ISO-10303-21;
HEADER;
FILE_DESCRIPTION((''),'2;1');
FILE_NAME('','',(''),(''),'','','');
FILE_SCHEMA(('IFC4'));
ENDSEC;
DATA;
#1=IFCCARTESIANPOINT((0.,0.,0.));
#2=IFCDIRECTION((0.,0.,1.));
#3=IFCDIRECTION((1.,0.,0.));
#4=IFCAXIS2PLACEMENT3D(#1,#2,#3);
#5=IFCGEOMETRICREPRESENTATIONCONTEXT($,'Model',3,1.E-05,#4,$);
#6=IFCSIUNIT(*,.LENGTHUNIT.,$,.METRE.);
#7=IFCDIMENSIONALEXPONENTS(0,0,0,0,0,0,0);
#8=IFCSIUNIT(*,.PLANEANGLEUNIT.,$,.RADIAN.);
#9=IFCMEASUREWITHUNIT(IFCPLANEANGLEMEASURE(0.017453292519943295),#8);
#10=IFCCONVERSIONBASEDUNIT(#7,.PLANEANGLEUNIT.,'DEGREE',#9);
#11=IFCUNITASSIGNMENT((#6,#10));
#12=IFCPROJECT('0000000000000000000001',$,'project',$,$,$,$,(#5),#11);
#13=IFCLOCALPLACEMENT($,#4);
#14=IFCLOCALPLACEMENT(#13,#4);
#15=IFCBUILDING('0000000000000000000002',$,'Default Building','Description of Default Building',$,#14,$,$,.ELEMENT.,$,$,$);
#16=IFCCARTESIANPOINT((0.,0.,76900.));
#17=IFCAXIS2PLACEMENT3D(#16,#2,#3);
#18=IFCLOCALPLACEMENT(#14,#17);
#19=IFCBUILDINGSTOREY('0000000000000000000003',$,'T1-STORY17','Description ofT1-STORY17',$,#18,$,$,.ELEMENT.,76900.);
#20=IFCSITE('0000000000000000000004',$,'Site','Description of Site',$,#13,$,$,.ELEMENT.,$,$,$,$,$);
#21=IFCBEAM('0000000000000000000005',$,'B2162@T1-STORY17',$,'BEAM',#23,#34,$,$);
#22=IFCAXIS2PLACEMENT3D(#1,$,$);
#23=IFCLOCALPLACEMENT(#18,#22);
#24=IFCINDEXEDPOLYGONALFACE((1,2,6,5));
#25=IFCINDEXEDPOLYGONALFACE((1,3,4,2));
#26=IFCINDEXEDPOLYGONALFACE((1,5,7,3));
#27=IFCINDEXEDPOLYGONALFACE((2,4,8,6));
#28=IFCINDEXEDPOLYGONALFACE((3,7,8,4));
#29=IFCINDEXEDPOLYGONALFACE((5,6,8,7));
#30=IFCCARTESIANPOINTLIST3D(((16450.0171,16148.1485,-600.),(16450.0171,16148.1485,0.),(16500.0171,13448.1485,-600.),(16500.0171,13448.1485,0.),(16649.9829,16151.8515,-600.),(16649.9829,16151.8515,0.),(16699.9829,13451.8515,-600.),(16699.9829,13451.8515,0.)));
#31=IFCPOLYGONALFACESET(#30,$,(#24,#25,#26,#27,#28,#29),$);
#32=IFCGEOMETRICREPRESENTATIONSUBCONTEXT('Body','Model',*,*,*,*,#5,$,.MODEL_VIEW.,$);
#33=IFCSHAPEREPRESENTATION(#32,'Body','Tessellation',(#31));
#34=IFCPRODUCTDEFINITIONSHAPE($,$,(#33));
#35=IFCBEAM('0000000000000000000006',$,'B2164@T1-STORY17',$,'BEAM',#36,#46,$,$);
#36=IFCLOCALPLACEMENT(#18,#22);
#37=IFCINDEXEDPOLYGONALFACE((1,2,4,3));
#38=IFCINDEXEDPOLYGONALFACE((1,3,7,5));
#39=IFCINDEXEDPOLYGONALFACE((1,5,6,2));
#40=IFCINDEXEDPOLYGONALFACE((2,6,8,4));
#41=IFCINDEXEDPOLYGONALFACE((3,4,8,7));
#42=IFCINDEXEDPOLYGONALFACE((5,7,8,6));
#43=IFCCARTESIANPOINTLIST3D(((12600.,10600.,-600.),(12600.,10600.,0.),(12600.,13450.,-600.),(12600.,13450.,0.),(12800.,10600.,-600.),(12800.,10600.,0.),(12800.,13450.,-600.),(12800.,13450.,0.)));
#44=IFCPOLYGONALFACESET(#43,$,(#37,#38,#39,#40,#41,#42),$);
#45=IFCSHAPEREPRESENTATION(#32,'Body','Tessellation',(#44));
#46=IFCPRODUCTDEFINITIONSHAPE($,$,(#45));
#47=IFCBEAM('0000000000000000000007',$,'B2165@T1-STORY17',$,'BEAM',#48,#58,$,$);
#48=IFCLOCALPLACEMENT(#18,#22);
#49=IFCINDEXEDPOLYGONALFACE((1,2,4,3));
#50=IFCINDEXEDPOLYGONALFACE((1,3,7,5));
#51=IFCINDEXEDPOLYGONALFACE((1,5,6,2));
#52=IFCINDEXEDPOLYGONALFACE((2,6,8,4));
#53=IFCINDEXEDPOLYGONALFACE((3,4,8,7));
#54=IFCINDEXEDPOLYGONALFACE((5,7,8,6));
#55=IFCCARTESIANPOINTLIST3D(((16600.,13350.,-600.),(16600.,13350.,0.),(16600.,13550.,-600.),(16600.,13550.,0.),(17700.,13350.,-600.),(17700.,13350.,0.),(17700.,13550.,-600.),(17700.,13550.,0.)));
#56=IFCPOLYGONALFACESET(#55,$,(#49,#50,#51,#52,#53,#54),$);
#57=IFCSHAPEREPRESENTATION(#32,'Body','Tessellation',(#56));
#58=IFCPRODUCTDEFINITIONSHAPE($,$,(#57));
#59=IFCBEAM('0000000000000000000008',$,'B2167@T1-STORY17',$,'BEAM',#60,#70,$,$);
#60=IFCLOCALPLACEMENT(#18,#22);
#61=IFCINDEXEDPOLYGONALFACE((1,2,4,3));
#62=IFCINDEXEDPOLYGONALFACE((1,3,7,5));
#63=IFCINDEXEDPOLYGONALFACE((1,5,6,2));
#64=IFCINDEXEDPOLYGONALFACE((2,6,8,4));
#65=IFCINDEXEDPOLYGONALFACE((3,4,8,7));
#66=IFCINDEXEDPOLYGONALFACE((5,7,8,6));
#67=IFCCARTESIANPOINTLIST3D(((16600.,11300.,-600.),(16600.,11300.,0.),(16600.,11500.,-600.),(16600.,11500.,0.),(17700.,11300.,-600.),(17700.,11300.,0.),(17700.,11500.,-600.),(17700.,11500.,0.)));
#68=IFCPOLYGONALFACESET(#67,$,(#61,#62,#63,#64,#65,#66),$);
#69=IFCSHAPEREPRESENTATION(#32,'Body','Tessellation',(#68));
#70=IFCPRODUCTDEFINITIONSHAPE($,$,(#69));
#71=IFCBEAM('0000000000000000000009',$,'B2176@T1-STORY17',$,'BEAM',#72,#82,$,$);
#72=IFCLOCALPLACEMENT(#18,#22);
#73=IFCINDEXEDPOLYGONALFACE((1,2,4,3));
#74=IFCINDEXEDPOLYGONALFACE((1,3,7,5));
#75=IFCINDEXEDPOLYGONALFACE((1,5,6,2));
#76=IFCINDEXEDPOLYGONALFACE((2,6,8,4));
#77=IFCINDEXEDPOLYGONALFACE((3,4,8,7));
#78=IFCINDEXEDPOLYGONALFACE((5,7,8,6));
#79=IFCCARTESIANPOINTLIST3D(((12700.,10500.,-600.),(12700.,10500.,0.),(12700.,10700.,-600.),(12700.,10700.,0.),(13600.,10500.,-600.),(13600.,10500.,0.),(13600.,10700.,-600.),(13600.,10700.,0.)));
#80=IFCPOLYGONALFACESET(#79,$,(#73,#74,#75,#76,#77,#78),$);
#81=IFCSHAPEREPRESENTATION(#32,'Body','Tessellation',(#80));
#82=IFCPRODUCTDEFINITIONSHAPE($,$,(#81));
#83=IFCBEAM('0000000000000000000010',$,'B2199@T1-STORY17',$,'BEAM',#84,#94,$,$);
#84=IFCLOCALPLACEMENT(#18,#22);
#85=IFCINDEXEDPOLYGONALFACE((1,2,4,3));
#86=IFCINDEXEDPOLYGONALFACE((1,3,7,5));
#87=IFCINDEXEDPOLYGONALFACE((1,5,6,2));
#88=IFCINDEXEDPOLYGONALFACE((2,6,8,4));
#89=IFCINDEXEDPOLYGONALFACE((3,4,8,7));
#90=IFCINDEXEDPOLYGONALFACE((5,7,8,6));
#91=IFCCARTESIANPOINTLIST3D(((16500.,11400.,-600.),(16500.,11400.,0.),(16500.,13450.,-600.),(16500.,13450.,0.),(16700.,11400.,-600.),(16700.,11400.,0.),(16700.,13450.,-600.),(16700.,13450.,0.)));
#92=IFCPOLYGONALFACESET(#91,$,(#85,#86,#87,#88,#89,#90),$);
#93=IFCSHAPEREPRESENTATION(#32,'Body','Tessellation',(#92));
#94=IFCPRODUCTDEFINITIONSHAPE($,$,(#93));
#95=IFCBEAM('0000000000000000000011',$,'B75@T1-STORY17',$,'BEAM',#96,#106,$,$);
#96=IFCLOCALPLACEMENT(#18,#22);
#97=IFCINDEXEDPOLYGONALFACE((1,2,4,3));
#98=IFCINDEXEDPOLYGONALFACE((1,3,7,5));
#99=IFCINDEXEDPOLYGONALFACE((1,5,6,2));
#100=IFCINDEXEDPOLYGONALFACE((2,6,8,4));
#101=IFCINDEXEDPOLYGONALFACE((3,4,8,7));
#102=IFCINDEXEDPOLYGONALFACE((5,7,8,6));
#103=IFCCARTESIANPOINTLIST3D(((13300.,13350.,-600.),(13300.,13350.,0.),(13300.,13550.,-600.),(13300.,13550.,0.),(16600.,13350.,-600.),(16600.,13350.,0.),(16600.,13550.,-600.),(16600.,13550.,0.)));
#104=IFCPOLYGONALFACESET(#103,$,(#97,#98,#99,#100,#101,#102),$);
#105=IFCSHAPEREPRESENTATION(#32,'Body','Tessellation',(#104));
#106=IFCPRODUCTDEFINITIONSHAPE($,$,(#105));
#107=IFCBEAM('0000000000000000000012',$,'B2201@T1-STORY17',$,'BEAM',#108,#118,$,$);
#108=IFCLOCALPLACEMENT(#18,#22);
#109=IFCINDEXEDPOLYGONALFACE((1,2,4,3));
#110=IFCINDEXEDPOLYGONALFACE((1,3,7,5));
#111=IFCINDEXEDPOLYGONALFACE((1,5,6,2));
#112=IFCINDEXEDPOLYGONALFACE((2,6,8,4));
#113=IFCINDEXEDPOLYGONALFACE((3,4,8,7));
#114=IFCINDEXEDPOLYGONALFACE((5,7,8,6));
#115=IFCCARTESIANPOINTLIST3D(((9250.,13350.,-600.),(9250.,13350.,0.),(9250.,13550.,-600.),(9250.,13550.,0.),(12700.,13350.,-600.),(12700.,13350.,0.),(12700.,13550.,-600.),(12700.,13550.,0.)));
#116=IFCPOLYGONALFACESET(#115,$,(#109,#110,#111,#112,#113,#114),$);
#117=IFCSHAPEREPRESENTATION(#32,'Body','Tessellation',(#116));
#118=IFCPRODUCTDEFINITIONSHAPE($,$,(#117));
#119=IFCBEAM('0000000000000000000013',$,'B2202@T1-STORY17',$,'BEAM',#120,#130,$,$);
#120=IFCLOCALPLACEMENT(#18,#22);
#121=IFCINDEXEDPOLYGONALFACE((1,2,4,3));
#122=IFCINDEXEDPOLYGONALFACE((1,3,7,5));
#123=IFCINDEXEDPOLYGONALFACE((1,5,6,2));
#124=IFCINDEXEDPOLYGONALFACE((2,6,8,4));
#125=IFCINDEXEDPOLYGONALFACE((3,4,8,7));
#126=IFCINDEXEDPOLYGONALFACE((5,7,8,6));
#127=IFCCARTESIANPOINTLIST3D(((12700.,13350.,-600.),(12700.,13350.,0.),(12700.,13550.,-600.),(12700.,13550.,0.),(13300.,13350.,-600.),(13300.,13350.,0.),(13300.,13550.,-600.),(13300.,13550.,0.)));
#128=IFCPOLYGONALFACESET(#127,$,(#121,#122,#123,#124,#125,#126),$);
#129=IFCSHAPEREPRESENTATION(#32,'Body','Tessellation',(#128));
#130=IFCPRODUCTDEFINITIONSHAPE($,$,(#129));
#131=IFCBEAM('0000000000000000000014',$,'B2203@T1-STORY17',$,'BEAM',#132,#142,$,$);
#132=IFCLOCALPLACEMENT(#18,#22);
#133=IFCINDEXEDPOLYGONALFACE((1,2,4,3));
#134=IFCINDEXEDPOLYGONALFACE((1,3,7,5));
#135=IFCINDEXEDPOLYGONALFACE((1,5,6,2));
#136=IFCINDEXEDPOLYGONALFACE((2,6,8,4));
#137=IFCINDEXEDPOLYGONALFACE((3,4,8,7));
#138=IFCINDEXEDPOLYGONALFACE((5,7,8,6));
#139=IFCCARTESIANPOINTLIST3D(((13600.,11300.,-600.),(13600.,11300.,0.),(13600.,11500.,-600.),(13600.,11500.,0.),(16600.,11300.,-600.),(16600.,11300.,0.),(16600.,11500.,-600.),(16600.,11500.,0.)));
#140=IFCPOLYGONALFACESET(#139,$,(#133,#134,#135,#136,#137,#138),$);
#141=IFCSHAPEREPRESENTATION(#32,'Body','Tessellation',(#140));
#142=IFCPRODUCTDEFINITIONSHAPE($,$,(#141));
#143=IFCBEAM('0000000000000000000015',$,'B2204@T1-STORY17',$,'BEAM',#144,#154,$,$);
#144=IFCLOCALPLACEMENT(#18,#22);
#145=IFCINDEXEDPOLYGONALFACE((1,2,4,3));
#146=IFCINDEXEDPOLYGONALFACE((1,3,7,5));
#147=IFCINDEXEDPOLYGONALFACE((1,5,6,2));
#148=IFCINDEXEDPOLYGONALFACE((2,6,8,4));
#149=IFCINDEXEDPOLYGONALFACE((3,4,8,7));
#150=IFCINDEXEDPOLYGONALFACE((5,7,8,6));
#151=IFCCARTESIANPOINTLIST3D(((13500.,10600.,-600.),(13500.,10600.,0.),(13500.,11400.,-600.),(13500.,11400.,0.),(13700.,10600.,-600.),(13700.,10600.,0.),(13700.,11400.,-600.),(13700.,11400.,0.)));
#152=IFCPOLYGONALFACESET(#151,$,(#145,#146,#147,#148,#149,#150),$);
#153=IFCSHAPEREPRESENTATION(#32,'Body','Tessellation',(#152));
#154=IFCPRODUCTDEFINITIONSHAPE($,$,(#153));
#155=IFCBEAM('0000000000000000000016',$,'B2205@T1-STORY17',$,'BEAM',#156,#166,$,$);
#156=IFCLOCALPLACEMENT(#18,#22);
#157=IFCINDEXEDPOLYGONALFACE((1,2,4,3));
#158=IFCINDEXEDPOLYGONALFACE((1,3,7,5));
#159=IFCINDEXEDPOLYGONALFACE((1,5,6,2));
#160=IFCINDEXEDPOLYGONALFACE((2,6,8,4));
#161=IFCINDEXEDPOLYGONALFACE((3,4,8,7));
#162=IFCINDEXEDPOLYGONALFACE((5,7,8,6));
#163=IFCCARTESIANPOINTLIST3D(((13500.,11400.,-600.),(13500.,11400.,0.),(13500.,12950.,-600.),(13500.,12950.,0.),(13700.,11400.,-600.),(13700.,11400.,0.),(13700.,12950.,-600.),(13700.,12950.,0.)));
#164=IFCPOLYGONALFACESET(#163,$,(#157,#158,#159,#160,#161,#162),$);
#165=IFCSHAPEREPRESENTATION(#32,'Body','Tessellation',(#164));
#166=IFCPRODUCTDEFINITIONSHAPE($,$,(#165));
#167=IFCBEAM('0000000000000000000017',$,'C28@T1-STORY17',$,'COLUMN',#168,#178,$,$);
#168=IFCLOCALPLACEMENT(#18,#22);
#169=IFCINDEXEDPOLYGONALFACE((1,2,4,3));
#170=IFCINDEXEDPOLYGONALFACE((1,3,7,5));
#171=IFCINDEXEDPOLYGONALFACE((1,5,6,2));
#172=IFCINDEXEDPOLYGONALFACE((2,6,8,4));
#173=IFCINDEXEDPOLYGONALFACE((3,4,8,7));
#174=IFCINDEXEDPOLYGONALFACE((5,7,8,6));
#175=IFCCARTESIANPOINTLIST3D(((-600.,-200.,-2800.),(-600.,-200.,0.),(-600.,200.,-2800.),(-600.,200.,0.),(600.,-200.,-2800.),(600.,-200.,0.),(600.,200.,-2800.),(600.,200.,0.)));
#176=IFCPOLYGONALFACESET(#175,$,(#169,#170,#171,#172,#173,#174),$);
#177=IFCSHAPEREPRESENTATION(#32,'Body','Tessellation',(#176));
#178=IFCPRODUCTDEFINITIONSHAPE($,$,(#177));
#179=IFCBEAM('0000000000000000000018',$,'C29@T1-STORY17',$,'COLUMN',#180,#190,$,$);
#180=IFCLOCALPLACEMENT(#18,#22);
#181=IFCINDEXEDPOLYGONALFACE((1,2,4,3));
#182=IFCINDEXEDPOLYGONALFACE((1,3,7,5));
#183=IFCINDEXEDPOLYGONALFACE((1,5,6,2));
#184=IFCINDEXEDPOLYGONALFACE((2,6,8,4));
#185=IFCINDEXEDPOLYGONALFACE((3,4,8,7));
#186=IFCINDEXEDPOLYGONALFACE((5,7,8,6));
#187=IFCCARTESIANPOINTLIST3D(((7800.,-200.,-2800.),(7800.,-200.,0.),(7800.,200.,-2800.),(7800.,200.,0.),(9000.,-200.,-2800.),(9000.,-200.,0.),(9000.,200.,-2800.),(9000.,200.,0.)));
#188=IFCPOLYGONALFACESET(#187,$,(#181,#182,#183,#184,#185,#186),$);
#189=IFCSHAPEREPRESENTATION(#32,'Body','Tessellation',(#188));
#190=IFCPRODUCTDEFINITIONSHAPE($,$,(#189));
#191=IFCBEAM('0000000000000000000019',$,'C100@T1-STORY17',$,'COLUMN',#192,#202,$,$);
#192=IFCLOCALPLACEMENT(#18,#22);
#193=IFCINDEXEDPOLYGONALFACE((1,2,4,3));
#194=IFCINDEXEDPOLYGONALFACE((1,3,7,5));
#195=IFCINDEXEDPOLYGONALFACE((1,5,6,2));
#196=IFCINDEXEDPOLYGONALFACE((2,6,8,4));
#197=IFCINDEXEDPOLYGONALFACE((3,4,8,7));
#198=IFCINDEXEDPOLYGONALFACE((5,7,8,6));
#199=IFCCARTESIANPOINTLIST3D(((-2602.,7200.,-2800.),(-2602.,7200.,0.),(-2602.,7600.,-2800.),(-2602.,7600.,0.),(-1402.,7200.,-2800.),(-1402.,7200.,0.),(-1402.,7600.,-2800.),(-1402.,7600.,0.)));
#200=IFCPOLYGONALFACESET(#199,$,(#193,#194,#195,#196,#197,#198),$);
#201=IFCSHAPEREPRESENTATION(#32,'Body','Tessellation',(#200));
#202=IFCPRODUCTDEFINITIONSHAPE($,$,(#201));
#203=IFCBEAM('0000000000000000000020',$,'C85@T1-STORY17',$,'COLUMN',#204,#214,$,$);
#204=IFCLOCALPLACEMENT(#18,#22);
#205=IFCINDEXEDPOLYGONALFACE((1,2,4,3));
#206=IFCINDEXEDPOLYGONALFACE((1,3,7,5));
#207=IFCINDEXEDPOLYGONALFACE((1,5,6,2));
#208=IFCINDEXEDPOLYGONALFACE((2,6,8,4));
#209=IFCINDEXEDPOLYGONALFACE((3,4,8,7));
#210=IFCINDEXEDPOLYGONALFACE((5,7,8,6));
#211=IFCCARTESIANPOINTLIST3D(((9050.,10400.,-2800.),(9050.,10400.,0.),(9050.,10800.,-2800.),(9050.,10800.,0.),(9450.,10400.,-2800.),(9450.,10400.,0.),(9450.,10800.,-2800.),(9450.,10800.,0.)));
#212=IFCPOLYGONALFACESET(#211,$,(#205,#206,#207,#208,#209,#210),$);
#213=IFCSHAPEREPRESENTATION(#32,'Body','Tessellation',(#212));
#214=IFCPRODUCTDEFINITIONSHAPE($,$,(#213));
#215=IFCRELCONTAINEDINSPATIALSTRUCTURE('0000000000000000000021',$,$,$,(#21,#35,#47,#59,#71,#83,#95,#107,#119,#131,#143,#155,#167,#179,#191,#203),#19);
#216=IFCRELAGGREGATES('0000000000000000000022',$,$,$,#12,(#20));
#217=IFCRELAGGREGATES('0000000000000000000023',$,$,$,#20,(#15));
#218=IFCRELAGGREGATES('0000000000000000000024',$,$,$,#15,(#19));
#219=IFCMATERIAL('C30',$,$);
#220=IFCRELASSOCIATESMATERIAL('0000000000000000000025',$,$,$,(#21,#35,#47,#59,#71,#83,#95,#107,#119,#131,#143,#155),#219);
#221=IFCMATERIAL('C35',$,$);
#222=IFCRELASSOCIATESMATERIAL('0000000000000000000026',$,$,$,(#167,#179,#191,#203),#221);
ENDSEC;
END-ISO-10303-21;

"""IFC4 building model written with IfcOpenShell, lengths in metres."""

from ifc_helpers import new_model, entity, si_unit, converted_unit, frame, origin_with_axes, place, context, subcontext, project, spatial, rectangle, extrude, material, element, save


model = new_model("IFC4")

# Units and contexts
model_context = context("Model", 3, precision=1e-05, world=origin_with_axes())
body_context = subcontext(model_context, "Body", "Model", "MODEL_VIEW")
ifc_project = project(units=[si_unit("LENGTHUNIT", "METRE"), converted_unit("PLANEANGLEUNIT", "DEGREE", entity("IfcPlaneAngleMeasure", 0.017453292519943295), si_unit("PLANEANGLEUNIT", "RADIAN"), dimensions=[0, 0, 0, 0, 0, 0, 0])], contexts=[model_context])

# Site, building, storey
site_placement = place(None, origin_with_axes())
site = spatial("IfcSite", under=ifc_project, at=site_placement, Name="Site", Description="Description of Site", CompositionType="ELEMENT")
building_placement = place(site_placement, origin_with_axes())
building = spatial("IfcBuilding", under=site, at=building_placement, Name="Default Building", Description="Description of Default Building", CompositionType="ELEMENT")
storey_placement = place(building_placement, frame((0.0, 0.0, 76900.0), z_axis=(0.0, 0.0, 1.0), x_axis=(1.0, 0.0, 0.0)))
storey = spatial("IfcBuildingStorey", under=building, at=storey_placement, Name="T1-STORY17", Description="Description ofT1-STORY17", CompositionType="ELEMENT", Elevation=76900.0)

# Beams
ifc_material_1 = material(Name="C30")
beam_1_placement = place(storey_placement, frame((16600.0, 13450.0, -300.0), z_axis=(-0.018515, 0.999829, 0.0), x_axis=(-0.999829, -0.018515, 0.0)))
element("IfcBeam", 1, at=beam_1_placement, inside=storey, material=ifc_material_1, Name="B2162@T1-STORY17", ObjectType="BEAM", context=body_context, shape_type="SweptSolid", body=[
    extrude(rectangle(XDim=200.0, YDim=600.0), origin_with_axes(), (0.0, 0.0, 1.0), 2700.4629),
])
beam_2_placement = place(storey_placement, frame((12700.0, 10600.0, -300.0), z_axis=(0.0, 1.0, 0.0), x_axis=(-1.0, 0.0, 0.0)))
element("IfcBeam", 2, at=beam_2_placement, inside=storey, material=ifc_material_1, Name="B2164@T1-STORY17", ObjectType="BEAM", context=body_context, shape_type="SweptSolid", body=[
    extrude(rectangle(XDim=200.0, YDim=600.0), origin_with_axes(), (0.0, 0.0, 1.0), 2850.0),
])
for number, where, z_axis, x_axis, name in (
    (3, (16600.0, 13450.0, -300.0), (1.0, 0.0, 0.0), (0.0, 1.0, 0.0), "B2165@T1-STORY17"),
    (4, (16600.0, 11400.0, -300.0), (1.0, 0.0, 0.0), (0.0, 1.0, 0.0), "B2167@T1-STORY17"),
):
    element("IfcBeam", number, at=place(storey_placement, frame(where, z_axis=z_axis, x_axis=x_axis)), inside=storey, material=ifc_material_1, Name=name, ObjectType="BEAM", context=body_context, shape_type="SweptSolid", body=[
        extrude(rectangle(XDim=200.0, YDim=600.0), origin_with_axes(), (0.0, 0.0, 1.0), 1100.0),
    ])
beam_3_placement = place(storey_placement, frame((12700.0, 10600.0, -300.0), z_axis=(1.0, 0.0, 0.0), x_axis=(0.0, 1.0, 0.0)))
element("IfcBeam", 5, at=beam_3_placement, inside=storey, material=ifc_material_1, Name="B2176@T1-STORY17", ObjectType="BEAM", context=body_context, shape_type="SweptSolid", body=[
    extrude(rectangle(XDim=200.0, YDim=600.0), origin_with_axes(), (0.0, 0.0, 1.0), 900.0),
])
beam_4_placement = place(storey_placement, frame((16600.0, 11400.0, -300.0), z_axis=(0.0, 1.0, 0.0), x_axis=(-1.0, 0.0, 0.0)))
element("IfcBeam", 6, at=beam_4_placement, inside=storey, material=ifc_material_1, Name="B2199@T1-STORY17", ObjectType="BEAM", context=body_context, shape_type="SweptSolid", body=[
    extrude(rectangle(XDim=200.0, YDim=600.0), origin_with_axes(), (0.0, 0.0, 1.0), 2050.0),
])
beam_5_placement = place(storey_placement, frame((13300.0, 13450.0, -300.0), z_axis=(1.0, 0.0, 0.0), x_axis=(0.0, 1.0, 0.0)))
element("IfcBeam", 7, at=beam_5_placement, inside=storey, material=ifc_material_1, Name="B75@T1-STORY17", ObjectType="BEAM", context=body_context, shape_type="SweptSolid", body=[
    extrude(rectangle(XDim=200.0, YDim=600.0), origin_with_axes(), (0.0, 0.0, 1.0), 3300.0),
])
beam_6_placement = place(storey_placement, frame((9250.0, 13450.0, -300.0), z_axis=(1.0, 0.0, 0.0), x_axis=(0.0, 1.0, 0.0)))
element("IfcBeam", 8, at=beam_6_placement, inside=storey, material=ifc_material_1, Name="B2201@T1-STORY17", ObjectType="BEAM", context=body_context, shape_type="SweptSolid", body=[
    extrude(rectangle(XDim=200.0, YDim=600.0), origin_with_axes(), (0.0, 0.0, 1.0), 3450.0),
])
beam_7_placement = place(storey_placement, frame((12700.0, 13450.0, -300.0), z_axis=(1.0, 0.0, 0.0), x_axis=(0.0, 1.0, 0.0)))
element("IfcBeam", 9, at=beam_7_placement, inside=storey, material=ifc_material_1, Name="B2202@T1-STORY17", ObjectType="BEAM", context=body_context, shape_type="SweptSolid", body=[
    extrude(rectangle(XDim=200.0, YDim=600.0), origin_with_axes(), (0.0, 0.0, 1.0), 600.0),
])
beam_8_placement = place(storey_placement, frame((13600.0, 11400.0, -300.0), z_axis=(1.0, 0.0, 0.0), x_axis=(0.0, 1.0, 0.0)))
element("IfcBeam", 10, at=beam_8_placement, inside=storey, material=ifc_material_1, Name="B2203@T1-STORY17", ObjectType="BEAM", context=body_context, shape_type="SweptSolid", body=[
    extrude(rectangle(XDim=200.0, YDim=600.0), origin_with_axes(), (0.0, 0.0, 1.0), 3000.0),
])
beam_9_placement = place(storey_placement, frame((13600.0, 10600.0, -300.0), z_axis=(0.0, 1.0, 0.0), x_axis=(-1.0, 0.0, 0.0)))
element("IfcBeam", 11, at=beam_9_placement, inside=storey, material=ifc_material_1, Name="B2204@T1-STORY17", ObjectType="BEAM", context=body_context, shape_type="SweptSolid", body=[
    extrude(rectangle(XDim=200.0, YDim=600.0), origin_with_axes(), (0.0, 0.0, 1.0), 800.0),
])
beam_10_placement = place(storey_placement, frame((13600.0, 11400.0, -300.0), z_axis=(0.0, 1.0, 0.0), x_axis=(-1.0, 0.0, 0.0)))
element("IfcBeam", 12, at=beam_10_placement, inside=storey, material=ifc_material_1, Name="B2205@T1-STORY17", ObjectType="BEAM", context=body_context, shape_type="SweptSolid", body=[
    extrude(rectangle(XDim=200.0, YDim=600.0), origin_with_axes(), (0.0, 0.0, 1.0), 1550.0),
])
ifc_material_2 = material(Name="C35")
for number, where, z_axis, x_axis, name in (
    (13, (0.0, 0.0, -2800.0), (0.0, 0.0, 1.0), (0.0, -1.0, 0.0), "C28@T1-STORY17"),
    (14, (8400.0, 0.0, -2800.0), (0.0, 0.0, 1.0), (0.0, -1.0, 0.0), "C29@T1-STORY17"),
    (15, (-2002.0, 7400.0, -2800.0), (0.0, 0.0, 1.0), (0.0, -1.0, 0.0), "C100@T1-STORY17"),
):
    element("IfcBeam", number, at=place(storey_placement, frame(where, z_axis=z_axis, x_axis=x_axis)), inside=storey, material=ifc_material_2, Name=name, ObjectType="COLUMN", context=body_context, shape_type="SweptSolid", body=[
        extrude(rectangle(XDim=400.0, YDim=1200.0), origin_with_axes(), (0.0, 0.0, 1.0), 2800.0),
    ])
for number, where, z_axis, x_axis, name in (
    (16, (9250.0, 10600.0, -2800.0), (0.0, 0.0, 1.0), (-1.0, 0.0, 0.0), "C85@T1-STORY17"),
):
    element("IfcBeam", number, at=place(storey_placement, frame(where, z_axis=z_axis, x_axis=x_axis)), inside=storey, material=ifc_material_2, Name=name, ObjectType="COLUMN", context=body_context, shape_type="SweptSolid", body=[
        extrude(rectangle(XDim=400.0, YDim=400.0), origin_with_axes(), (0.0, 0.0, 1.0), 2800.0),
    ])

save(model, "model.ifc")
